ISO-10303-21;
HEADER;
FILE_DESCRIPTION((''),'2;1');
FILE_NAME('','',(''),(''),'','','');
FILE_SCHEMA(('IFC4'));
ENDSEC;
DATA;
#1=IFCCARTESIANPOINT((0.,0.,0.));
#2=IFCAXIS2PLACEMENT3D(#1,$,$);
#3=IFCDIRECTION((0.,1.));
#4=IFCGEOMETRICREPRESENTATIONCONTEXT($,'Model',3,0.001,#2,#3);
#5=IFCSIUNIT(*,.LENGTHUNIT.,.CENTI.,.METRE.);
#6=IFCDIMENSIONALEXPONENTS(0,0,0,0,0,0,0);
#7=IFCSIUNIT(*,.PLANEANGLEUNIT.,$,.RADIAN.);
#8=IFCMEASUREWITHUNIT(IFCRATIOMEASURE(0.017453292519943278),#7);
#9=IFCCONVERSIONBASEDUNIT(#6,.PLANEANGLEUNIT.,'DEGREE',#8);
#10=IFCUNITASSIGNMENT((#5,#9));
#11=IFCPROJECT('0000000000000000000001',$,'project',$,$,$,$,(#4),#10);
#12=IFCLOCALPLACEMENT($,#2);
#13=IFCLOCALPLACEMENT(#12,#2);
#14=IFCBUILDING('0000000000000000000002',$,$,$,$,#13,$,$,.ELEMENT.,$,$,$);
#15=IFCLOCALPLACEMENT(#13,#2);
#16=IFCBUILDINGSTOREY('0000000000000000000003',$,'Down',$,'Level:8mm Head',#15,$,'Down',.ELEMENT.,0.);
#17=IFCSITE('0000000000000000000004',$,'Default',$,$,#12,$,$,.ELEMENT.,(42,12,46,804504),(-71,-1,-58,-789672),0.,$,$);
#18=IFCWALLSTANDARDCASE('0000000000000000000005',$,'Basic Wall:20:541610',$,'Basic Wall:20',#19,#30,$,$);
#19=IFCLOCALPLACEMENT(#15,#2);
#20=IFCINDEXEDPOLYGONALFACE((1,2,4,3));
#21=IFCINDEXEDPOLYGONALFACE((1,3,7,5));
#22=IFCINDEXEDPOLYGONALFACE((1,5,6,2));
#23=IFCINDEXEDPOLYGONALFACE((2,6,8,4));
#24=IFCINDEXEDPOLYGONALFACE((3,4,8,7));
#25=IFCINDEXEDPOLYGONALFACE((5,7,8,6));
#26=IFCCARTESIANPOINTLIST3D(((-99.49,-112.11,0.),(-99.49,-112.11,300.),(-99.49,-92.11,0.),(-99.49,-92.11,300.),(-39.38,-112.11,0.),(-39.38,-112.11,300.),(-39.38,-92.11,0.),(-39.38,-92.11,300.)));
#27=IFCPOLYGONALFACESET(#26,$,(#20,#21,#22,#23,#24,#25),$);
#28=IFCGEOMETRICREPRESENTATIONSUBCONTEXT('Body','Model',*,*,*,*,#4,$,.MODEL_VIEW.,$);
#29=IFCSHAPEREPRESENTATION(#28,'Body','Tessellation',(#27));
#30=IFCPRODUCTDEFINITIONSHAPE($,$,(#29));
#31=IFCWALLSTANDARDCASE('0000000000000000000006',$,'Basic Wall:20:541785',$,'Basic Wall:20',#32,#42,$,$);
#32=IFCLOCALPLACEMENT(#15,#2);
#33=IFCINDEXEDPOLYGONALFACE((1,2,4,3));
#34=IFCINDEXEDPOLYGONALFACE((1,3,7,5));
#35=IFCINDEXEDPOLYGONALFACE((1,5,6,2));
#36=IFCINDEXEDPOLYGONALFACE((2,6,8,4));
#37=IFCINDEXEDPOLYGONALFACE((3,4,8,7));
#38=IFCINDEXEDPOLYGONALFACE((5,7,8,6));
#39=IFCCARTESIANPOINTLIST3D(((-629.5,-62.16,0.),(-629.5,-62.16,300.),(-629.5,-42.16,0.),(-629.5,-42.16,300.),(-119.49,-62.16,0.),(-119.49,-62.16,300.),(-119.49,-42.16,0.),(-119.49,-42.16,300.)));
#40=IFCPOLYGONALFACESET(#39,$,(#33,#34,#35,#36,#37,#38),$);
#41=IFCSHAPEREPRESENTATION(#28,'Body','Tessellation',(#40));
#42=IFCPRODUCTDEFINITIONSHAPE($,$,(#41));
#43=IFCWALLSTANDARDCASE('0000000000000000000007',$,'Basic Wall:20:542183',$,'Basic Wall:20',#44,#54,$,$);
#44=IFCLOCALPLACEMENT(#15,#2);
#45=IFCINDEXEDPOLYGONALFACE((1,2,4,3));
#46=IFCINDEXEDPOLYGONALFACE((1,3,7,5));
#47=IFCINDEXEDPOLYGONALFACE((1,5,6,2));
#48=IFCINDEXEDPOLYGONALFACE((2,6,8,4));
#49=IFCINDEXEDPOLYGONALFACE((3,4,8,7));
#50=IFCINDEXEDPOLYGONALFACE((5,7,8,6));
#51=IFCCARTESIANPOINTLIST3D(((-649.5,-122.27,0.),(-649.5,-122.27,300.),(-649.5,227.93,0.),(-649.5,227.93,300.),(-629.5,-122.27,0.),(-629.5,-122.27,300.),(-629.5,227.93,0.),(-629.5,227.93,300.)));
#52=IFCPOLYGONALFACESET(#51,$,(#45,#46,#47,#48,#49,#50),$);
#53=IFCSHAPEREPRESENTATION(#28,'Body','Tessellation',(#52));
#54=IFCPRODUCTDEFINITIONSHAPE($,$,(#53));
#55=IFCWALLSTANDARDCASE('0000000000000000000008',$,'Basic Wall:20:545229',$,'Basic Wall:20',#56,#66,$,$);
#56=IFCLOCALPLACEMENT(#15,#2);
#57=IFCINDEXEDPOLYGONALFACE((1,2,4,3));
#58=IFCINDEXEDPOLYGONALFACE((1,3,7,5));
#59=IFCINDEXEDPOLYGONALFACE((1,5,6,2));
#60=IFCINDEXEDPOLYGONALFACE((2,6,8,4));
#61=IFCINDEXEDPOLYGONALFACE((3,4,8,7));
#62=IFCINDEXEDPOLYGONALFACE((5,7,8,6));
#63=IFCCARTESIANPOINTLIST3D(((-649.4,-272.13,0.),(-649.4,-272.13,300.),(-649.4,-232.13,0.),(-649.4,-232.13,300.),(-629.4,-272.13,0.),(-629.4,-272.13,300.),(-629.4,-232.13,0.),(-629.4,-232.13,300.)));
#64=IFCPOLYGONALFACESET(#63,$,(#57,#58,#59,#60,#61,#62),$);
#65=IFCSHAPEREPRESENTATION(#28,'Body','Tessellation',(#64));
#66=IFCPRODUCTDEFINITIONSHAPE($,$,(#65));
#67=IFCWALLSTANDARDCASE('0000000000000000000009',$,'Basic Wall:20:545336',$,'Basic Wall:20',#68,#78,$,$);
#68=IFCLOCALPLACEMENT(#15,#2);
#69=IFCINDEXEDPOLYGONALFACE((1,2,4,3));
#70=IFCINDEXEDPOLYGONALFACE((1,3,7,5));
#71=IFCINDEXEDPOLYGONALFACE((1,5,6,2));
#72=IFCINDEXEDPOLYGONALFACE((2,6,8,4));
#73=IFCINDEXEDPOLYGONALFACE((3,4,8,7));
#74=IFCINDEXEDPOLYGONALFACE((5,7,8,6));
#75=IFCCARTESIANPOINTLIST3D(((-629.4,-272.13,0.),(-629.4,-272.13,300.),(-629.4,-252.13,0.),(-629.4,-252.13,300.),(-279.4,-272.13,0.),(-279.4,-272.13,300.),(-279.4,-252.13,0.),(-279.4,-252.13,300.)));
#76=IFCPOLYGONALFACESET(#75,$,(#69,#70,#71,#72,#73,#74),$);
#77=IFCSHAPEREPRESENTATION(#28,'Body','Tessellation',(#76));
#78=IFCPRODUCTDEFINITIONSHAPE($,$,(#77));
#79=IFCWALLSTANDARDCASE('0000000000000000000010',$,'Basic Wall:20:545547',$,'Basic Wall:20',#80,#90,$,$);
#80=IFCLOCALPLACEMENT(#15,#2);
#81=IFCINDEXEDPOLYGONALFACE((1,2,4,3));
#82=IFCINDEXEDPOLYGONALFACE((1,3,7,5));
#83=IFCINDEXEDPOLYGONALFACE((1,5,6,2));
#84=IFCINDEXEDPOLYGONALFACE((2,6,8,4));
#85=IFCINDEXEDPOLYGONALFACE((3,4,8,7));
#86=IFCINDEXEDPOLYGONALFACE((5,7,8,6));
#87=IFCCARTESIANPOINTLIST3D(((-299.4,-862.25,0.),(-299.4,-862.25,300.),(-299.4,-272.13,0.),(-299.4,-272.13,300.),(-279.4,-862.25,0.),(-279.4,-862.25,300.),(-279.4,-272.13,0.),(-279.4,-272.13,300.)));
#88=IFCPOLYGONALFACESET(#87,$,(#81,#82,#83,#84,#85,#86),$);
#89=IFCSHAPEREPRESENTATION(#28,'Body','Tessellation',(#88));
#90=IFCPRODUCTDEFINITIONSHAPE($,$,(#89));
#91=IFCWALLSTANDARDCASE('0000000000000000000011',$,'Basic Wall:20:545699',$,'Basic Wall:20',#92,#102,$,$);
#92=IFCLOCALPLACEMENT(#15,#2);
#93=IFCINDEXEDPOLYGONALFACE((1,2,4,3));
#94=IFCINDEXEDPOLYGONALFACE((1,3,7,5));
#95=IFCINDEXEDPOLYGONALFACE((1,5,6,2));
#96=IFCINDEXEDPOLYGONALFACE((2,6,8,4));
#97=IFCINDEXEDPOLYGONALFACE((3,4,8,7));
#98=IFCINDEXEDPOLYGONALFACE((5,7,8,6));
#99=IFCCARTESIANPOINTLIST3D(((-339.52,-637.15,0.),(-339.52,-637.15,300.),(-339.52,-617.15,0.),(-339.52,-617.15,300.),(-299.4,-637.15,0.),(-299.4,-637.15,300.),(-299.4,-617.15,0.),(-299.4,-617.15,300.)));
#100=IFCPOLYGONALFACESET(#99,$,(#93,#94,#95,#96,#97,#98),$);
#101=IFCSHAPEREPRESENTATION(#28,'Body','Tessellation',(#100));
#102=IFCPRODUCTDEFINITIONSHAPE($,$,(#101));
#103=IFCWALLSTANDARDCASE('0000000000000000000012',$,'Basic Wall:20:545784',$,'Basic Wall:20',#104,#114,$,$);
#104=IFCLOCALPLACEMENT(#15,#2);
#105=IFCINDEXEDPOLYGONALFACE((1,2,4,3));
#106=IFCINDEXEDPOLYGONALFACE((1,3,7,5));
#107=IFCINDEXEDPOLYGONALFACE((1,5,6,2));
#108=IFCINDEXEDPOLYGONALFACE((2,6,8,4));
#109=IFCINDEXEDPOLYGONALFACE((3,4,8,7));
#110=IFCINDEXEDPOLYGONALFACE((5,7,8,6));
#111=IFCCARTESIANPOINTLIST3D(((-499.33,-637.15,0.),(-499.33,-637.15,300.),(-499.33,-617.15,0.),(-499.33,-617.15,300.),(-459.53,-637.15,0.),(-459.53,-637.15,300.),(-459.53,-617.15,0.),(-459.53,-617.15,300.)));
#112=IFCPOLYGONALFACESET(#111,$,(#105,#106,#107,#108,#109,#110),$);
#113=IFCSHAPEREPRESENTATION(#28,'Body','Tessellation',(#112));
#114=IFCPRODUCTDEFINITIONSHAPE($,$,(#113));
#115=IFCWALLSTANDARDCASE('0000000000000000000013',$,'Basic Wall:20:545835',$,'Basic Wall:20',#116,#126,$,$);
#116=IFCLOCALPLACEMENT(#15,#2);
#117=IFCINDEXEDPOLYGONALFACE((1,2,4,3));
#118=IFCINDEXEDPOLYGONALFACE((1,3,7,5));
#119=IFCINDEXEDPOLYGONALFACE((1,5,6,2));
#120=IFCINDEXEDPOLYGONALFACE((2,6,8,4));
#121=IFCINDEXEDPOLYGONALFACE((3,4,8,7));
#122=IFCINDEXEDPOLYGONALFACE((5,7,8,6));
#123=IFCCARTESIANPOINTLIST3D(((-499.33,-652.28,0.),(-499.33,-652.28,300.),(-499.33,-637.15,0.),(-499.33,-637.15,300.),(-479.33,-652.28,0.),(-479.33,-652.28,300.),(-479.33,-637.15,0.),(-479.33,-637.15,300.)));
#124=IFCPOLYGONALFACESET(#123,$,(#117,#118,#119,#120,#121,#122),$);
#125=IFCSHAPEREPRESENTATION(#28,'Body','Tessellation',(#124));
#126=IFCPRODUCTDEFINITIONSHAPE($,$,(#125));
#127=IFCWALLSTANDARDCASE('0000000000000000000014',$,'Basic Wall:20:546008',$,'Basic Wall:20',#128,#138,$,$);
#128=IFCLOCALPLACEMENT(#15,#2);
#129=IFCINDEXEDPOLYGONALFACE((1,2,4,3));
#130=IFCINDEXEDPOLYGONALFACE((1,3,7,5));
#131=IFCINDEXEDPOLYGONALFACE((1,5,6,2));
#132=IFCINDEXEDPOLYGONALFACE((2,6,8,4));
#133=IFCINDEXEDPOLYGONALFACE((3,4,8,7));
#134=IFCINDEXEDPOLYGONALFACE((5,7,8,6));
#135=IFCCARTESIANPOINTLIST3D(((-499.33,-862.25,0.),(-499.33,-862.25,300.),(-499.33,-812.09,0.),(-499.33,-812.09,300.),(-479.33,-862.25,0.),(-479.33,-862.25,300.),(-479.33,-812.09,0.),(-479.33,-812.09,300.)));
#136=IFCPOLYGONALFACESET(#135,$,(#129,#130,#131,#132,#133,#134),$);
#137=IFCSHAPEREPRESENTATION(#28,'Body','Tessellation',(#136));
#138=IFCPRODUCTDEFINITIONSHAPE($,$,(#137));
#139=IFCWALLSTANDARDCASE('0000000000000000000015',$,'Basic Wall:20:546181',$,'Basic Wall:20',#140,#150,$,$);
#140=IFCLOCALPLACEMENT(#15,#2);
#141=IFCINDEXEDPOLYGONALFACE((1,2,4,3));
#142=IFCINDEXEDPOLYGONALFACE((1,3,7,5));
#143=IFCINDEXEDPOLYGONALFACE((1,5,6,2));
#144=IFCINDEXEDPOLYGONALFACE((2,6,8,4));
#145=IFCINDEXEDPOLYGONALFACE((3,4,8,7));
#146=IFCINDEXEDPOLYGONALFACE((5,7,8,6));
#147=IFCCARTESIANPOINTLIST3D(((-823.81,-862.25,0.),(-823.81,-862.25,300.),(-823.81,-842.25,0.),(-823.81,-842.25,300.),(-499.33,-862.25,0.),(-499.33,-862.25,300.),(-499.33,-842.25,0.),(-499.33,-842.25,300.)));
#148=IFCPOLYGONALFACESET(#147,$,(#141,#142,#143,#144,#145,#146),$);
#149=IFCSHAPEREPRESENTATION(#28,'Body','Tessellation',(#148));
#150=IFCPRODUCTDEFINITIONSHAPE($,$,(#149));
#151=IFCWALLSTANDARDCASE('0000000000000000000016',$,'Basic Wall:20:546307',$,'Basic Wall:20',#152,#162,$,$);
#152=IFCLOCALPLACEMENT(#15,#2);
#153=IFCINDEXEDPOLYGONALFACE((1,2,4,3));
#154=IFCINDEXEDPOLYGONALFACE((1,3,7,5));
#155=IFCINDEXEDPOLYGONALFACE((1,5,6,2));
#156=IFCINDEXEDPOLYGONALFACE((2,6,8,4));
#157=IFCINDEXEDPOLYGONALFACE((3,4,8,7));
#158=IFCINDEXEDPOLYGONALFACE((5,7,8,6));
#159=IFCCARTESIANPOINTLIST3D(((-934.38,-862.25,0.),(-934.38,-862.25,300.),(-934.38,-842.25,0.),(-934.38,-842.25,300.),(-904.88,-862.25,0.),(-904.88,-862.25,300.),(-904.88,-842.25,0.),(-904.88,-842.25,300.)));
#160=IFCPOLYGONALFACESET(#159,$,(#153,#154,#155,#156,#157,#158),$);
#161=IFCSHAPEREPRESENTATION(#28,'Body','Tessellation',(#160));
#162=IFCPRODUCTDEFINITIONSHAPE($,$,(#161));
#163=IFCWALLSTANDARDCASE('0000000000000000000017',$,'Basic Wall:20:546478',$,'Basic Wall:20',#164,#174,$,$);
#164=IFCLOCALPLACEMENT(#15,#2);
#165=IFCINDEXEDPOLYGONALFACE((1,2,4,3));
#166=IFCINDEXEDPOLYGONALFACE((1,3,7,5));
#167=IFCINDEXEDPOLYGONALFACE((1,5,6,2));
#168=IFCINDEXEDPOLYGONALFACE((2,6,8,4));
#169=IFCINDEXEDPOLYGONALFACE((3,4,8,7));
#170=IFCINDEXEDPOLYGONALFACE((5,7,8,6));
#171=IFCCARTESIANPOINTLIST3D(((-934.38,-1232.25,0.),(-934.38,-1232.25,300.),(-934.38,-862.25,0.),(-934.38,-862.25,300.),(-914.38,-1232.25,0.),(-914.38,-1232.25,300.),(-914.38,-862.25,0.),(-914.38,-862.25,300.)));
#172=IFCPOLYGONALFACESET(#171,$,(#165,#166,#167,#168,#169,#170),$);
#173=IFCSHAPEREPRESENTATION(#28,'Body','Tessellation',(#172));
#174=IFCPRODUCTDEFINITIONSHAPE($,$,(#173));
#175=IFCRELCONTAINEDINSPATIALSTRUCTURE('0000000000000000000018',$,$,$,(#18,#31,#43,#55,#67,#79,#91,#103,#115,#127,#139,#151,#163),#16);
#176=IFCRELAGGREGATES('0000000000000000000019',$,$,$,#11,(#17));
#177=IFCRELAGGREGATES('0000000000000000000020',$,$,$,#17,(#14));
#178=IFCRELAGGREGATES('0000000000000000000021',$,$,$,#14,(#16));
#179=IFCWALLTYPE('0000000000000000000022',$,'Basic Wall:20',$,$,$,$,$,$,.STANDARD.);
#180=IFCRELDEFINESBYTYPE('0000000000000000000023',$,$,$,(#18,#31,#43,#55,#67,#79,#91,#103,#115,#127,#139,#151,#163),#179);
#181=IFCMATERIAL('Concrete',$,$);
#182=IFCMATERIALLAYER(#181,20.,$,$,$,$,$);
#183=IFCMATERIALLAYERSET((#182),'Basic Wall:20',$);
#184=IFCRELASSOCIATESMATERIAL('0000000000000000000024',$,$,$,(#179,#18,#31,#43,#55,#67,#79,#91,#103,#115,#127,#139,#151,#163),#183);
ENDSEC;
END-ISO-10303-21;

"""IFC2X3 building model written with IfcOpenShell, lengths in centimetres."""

from ifc_helpers import new_model, entity, si_unit, converted_unit, direction, frame, frame_2d, origin, place, context, subcontext, project, spatial, rectangle, extrude, material, layer, layer_set, layer_usage, type_object, element, save


model = new_model("IFC2X3")

# Units and contexts
model_context = context("Model", 3, precision=0.001, world=origin(), true_north=direction((0.0, 1.0)))
body_context = subcontext(model_context, "Body", "Model", "MODEL_VIEW")
ifc_project = project(units=[si_unit("LENGTHUNIT", "METRE", prefix="CENTI"), converted_unit("PLANEANGLEUNIT", "DEGREE", entity("IfcRatioMeasure", 0.017453292519943278), si_unit("PLANEANGLEUNIT", "RADIAN"), dimensions=[0, 0, 0, 0, 0, 0, 0])], contexts=[model_context])

# Site, building, storey
site_placement = place(None, origin())
site = spatial("IfcSite", under=ifc_project, at=site_placement, Name="Default", CompositionType="ELEMENT", RefLatitude=(42, 12, 46, 804504), RefLongitude=(-71, -1, -58, -789672), RefElevation=0.0)
building_placement = place(site_placement, origin())
building = spatial("IfcBuilding", under=site, at=building_placement, CompositionType="ELEMENT")
storey_placement = place(building_placement, origin())
storey = spatial("IfcBuildingStorey", under=building, at=storey_placement, Name="Down", ObjectType="Level:8mm Head", LongName="Down", CompositionType="ELEMENT", Elevation=0.0)

# Walls
ifc_material = material(Name="Concrete")
ifc_layer_1 = layer(ifc_material, 20.0)
ifc_layer_set_1 = layer_set([ifc_layer_1], Name="Basic Wall:20")
ifc_layer_usage_1 = layer_usage(ifc_layer_set_1, "AXIS2", "POSITIVE", -10.0)
wall_type_1 = type_object("IfcWallType", Name="Basic Wall:20", PredefinedType="STANDARD", material=ifc_layer_set_1)
wall_1_placement = place(storey_placement, frame((-99.49, -102.11, 0.0)))
element("IfcWallStandardCase", 1, at=wall_1_placement, inside=storey, type_object=wall_type_1, material=ifc_layer_usage_1, Name="Basic Wall:20:541610", ObjectType="Basic Wall:20", context=body_context, shape_type="SweptSolid", body=[
    extrude(rectangle(XDim=60.11, YDim=20.0, at=frame_2d((30.06, 0.0), x_axis=(-1.0, 0.0))), origin(), (0.0, 0.0, 1.0), 300.0),
])
ifc_layer_usage_2 = layer_usage(ifc_layer_set_1, "AXIS2", "NEGATIVE", 10.0)
wall_2_placement = place(storey_placement, frame((-119.49, -52.16, 0.0), z_axis=(0.0, 0.0, 1.0), x_axis=(-1.0, 0.0, 0.0)))
element("IfcWallStandardCase", 2, at=wall_2_placement, inside=storey, type_object=wall_type_1, material=ifc_layer_usage_2, Name="Basic Wall:20:541785", ObjectType="Basic Wall:20", context=body_context, shape_type="SweptSolid", body=[
    extrude(rectangle(XDim=510.01, YDim=20.0, at=frame_2d((255.0, 0.0), x_axis=(-1.0, 0.0))), origin(), (0.0, 0.0, 1.0), 300.0),
])
ifc_layer_usage_3 = layer_usage(ifc_layer_set_1, "AXIS2", "NEGATIVE", 10.0)
wall_3_placement = place(storey_placement, frame((-639.5, -122.27, 0.0), z_axis=(0.0, 0.0, 1.0), x_axis=(0.0, 1.0, 0.0)))
element("IfcWallStandardCase", 3, at=wall_3_placement, inside=storey, type_object=wall_type_1, material=ifc_layer_usage_3, Name="Basic Wall:20:542183", ObjectType="Basic Wall:20", context=body_context, shape_type="SweptSolid", body=[
    extrude(rectangle(XDim=350.2, YDim=20.0, at=frame_2d((175.1, 0.0), x_axis=(-1.0, 0.0))), origin(), (0.0, 0.0, 1.0), 300.0),
])
ifc_layer_usage_4 = layer_usage(ifc_layer_set_1, "AXIS2", "POSITIVE", -10.0)
wall_4_placement = place(storey_placement, frame((-639.4, -232.13, 0.0), z_axis=(0.0, 0.0, 1.0), x_axis=(0.0, -1.0, 0.0)))
element("IfcWallStandardCase", 4, at=wall_4_placement, inside=storey, type_object=wall_type_1, material=ifc_layer_usage_4, Name="Basic Wall:20:545229", ObjectType="Basic Wall:20", context=body_context, shape_type="SweptSolid", body=[
    extrude(rectangle(XDim=40.0, YDim=20.0, at=frame_2d((20.0, 0.0), x_axis=(-1.0, 0.0))), origin(), (0.0, 0.0, 1.0), 300.0),
])
ifc_layer_usage_5 = layer_usage(ifc_layer_set_1, "AXIS2", "POSITIVE", -10.0)
wall_5_placement = place(storey_placement, frame((-629.4, -262.13, 0.0)))
element("IfcWallStandardCase", 5, at=wall_5_placement, inside=storey, type_object=wall_type_1, material=ifc_layer_usage_5, Name="Basic Wall:20:545336", ObjectType="Basic Wall:20", context=body_context, shape_type="SweptSolid", body=[
    extrude(rectangle(XDim=350.0, YDim=20.0, at=frame_2d((175.0, 0.0), x_axis=(-1.0, 0.0))), origin(), (0.0, 0.0, 1.0), 300.0),
])
ifc_layer_usage_6 = layer_usage(ifc_layer_set_1, "AXIS2", "NEGATIVE", 10.0)
wall_6_placement = place(storey_placement, frame((-289.4, -272.13, 0.0), z_axis=(0.0, 0.0, 1.0), x_axis=(0.0, -1.0, 0.0)))
element("IfcWallStandardCase", 6, at=wall_6_placement, inside=storey, type_object=wall_type_1, material=ifc_layer_usage_6, Name="Basic Wall:20:545547", ObjectType="Basic Wall:20", context=body_context, shape_type="SweptSolid", body=[
    extrude(rectangle(XDim=590.12, YDim=20.0, at=frame_2d((295.06, 0.0), x_axis=(-1.0, 0.0))), origin(), (0.0, 0.0, 1.0), 300.0),
])
ifc_layer_usage_7 = layer_usage(ifc_layer_set_1, "AXIS2", "POSITIVE", -10.0)
wall_7_placement = place(storey_placement, frame((-299.4, -627.15, 0.0), z_axis=(0.0, 0.0, 1.0), x_axis=(-1.0, 0.0, 0.0)))
element("IfcWallStandardCase", 7, at=wall_7_placement, inside=storey, type_object=wall_type_1, material=ifc_layer_usage_7, Name="Basic Wall:20:545699", ObjectType="Basic Wall:20", context=body_context, shape_type="SweptSolid", body=[
    extrude(rectangle(XDim=40.12, YDim=20.0, at=frame_2d((20.06, 0.0), x_axis=(-1.0, 0.0))), origin(), (0.0, 0.0, 1.0), 300.0),
])
ifc_layer_usage_8 = layer_usage(ifc_layer_set_1, "AXIS2", "POSITIVE", -10.0)
wall_8_placement = place(storey_placement, frame((-459.53, -627.15, 0.0), z_axis=(0.0, 0.0, 1.0), x_axis=(-1.0, 0.0, 0.0)))
element("IfcWallStandardCase", 8, at=wall_8_placement, inside=storey, type_object=wall_type_1, material=ifc_layer_usage_8, Name="Basic Wall:20:545784", ObjectType="Basic Wall:20", context=body_context, shape_type="SweptSolid", body=[
    extrude(rectangle(XDim=39.79, YDim=20.0, at=frame_2d((19.9, 0.0), x_axis=(-1.0, 0.0))), origin(), (0.0, 0.0, 1.0), 300.0),
])
ifc_layer_usage_9 = layer_usage(ifc_layer_set_1, "AXIS2", "POSITIVE", -10.0)
wall_9_placement = place(storey_placement, frame((-489.33, -637.15, 0.0), z_axis=(0.0, 0.0, 1.0), x_axis=(0.0, -1.0, 0.0)))
element("IfcWallStandardCase", 9, at=wall_9_placement, inside=storey, type_object=wall_type_1, material=ifc_layer_usage_9, Name="Basic Wall:20:545835", ObjectType="Basic Wall:20", context=body_context, shape_type="SweptSolid", body=[
    extrude(rectangle(XDim=15.14, YDim=20.0, at=frame_2d((7.57, 0.0), x_axis=(-1.0, 0.0))), origin(), (0.0, 0.0, 1.0), 300.0),
])
ifc_layer_usage_10 = layer_usage(ifc_layer_set_1, "AXIS2", "POSITIVE", -10.0)
wall_10_placement = place(storey_placement, frame((-489.33, -812.09, 0.0), z_axis=(0.0, 0.0, 1.0), x_axis=(0.0, -1.0, 0.0)))
element("IfcWallStandardCase", 10, at=wall_10_placement, inside=storey, type_object=wall_type_1, material=ifc_layer_usage_10, Name="Basic Wall:20:546008", ObjectType="Basic Wall:20", context=body_context, shape_type="SweptSolid", body=[
    extrude(rectangle(XDim=50.16, YDim=20.0, at=frame_2d((25.08, 0.0), x_axis=(-1.0, 0.0))), origin(), (0.0, 0.0, 1.0), 300.0),
])
ifc_layer_usage_11 = layer_usage(ifc_layer_set_1, "AXIS2", "NEGATIVE", 10.0)
wall_11_placement = place(storey_placement, frame((-499.33, -852.25, 0.0), z_axis=(0.0, 0.0, 1.0), x_axis=(-1.0, 0.0, 0.0)))
element("IfcWallStandardCase", 11, at=wall_11_placement, inside=storey, type_object=wall_type_1, material=ifc_layer_usage_11, Name="Basic Wall:20:546181", ObjectType="Basic Wall:20", context=body_context, shape_type="SweptSolid", body=[
    extrude(rectangle(XDim=324.48, YDim=20.0, at=frame_2d((162.24, 0.0), x_axis=(-1.0, 0.0))), origin(), (0.0, 0.0, 1.0), 300.0),
])
ifc_layer_usage_12 = layer_usage(ifc_layer_set_1, "AXIS2", "NEGATIVE", 10.0)
wall_12_placement = place(storey_placement, frame((-904.88, -852.25, 0.0), z_axis=(0.0, 0.0, 1.0), x_axis=(-1.0, 0.0, 0.0)))
element("IfcWallStandardCase", 12, at=wall_12_placement, inside=storey, type_object=wall_type_1, material=ifc_layer_usage_12, Name="Basic Wall:20:546307", ObjectType="Basic Wall:20", context=body_context, shape_type="SweptSolid", body=[
    extrude(rectangle(XDim=29.5, YDim=20.0, at=frame_2d((14.75, 0.0), x_axis=(-1.0, 0.0))), origin(), (0.0, 0.0, 1.0), 300.0),
])
ifc_layer_usage_13 = layer_usage(ifc_layer_set_1, "AXIS2", "POSITIVE", -10.0)
wall_13_placement = place(storey_placement, frame((-924.38, -862.25, 0.0), z_axis=(0.0, 0.0, 1.0), x_axis=(0.0, -1.0, 0.0)))
element("IfcWallStandardCase", 13, at=wall_13_placement, inside=storey, type_object=wall_type_1, material=ifc_layer_usage_13, Name="Basic Wall:20:546478", ObjectType="Basic Wall:20", context=body_context, shape_type="SweptSolid", body=[
    extrude(rectangle(XDim=369.99, YDim=20.0, at=frame_2d((185.0, 0.0), x_axis=(-1.0, 0.0))), origin(), (0.0, 0.0, 1.0), 300.0),
])

save(model, "model.ifc")
